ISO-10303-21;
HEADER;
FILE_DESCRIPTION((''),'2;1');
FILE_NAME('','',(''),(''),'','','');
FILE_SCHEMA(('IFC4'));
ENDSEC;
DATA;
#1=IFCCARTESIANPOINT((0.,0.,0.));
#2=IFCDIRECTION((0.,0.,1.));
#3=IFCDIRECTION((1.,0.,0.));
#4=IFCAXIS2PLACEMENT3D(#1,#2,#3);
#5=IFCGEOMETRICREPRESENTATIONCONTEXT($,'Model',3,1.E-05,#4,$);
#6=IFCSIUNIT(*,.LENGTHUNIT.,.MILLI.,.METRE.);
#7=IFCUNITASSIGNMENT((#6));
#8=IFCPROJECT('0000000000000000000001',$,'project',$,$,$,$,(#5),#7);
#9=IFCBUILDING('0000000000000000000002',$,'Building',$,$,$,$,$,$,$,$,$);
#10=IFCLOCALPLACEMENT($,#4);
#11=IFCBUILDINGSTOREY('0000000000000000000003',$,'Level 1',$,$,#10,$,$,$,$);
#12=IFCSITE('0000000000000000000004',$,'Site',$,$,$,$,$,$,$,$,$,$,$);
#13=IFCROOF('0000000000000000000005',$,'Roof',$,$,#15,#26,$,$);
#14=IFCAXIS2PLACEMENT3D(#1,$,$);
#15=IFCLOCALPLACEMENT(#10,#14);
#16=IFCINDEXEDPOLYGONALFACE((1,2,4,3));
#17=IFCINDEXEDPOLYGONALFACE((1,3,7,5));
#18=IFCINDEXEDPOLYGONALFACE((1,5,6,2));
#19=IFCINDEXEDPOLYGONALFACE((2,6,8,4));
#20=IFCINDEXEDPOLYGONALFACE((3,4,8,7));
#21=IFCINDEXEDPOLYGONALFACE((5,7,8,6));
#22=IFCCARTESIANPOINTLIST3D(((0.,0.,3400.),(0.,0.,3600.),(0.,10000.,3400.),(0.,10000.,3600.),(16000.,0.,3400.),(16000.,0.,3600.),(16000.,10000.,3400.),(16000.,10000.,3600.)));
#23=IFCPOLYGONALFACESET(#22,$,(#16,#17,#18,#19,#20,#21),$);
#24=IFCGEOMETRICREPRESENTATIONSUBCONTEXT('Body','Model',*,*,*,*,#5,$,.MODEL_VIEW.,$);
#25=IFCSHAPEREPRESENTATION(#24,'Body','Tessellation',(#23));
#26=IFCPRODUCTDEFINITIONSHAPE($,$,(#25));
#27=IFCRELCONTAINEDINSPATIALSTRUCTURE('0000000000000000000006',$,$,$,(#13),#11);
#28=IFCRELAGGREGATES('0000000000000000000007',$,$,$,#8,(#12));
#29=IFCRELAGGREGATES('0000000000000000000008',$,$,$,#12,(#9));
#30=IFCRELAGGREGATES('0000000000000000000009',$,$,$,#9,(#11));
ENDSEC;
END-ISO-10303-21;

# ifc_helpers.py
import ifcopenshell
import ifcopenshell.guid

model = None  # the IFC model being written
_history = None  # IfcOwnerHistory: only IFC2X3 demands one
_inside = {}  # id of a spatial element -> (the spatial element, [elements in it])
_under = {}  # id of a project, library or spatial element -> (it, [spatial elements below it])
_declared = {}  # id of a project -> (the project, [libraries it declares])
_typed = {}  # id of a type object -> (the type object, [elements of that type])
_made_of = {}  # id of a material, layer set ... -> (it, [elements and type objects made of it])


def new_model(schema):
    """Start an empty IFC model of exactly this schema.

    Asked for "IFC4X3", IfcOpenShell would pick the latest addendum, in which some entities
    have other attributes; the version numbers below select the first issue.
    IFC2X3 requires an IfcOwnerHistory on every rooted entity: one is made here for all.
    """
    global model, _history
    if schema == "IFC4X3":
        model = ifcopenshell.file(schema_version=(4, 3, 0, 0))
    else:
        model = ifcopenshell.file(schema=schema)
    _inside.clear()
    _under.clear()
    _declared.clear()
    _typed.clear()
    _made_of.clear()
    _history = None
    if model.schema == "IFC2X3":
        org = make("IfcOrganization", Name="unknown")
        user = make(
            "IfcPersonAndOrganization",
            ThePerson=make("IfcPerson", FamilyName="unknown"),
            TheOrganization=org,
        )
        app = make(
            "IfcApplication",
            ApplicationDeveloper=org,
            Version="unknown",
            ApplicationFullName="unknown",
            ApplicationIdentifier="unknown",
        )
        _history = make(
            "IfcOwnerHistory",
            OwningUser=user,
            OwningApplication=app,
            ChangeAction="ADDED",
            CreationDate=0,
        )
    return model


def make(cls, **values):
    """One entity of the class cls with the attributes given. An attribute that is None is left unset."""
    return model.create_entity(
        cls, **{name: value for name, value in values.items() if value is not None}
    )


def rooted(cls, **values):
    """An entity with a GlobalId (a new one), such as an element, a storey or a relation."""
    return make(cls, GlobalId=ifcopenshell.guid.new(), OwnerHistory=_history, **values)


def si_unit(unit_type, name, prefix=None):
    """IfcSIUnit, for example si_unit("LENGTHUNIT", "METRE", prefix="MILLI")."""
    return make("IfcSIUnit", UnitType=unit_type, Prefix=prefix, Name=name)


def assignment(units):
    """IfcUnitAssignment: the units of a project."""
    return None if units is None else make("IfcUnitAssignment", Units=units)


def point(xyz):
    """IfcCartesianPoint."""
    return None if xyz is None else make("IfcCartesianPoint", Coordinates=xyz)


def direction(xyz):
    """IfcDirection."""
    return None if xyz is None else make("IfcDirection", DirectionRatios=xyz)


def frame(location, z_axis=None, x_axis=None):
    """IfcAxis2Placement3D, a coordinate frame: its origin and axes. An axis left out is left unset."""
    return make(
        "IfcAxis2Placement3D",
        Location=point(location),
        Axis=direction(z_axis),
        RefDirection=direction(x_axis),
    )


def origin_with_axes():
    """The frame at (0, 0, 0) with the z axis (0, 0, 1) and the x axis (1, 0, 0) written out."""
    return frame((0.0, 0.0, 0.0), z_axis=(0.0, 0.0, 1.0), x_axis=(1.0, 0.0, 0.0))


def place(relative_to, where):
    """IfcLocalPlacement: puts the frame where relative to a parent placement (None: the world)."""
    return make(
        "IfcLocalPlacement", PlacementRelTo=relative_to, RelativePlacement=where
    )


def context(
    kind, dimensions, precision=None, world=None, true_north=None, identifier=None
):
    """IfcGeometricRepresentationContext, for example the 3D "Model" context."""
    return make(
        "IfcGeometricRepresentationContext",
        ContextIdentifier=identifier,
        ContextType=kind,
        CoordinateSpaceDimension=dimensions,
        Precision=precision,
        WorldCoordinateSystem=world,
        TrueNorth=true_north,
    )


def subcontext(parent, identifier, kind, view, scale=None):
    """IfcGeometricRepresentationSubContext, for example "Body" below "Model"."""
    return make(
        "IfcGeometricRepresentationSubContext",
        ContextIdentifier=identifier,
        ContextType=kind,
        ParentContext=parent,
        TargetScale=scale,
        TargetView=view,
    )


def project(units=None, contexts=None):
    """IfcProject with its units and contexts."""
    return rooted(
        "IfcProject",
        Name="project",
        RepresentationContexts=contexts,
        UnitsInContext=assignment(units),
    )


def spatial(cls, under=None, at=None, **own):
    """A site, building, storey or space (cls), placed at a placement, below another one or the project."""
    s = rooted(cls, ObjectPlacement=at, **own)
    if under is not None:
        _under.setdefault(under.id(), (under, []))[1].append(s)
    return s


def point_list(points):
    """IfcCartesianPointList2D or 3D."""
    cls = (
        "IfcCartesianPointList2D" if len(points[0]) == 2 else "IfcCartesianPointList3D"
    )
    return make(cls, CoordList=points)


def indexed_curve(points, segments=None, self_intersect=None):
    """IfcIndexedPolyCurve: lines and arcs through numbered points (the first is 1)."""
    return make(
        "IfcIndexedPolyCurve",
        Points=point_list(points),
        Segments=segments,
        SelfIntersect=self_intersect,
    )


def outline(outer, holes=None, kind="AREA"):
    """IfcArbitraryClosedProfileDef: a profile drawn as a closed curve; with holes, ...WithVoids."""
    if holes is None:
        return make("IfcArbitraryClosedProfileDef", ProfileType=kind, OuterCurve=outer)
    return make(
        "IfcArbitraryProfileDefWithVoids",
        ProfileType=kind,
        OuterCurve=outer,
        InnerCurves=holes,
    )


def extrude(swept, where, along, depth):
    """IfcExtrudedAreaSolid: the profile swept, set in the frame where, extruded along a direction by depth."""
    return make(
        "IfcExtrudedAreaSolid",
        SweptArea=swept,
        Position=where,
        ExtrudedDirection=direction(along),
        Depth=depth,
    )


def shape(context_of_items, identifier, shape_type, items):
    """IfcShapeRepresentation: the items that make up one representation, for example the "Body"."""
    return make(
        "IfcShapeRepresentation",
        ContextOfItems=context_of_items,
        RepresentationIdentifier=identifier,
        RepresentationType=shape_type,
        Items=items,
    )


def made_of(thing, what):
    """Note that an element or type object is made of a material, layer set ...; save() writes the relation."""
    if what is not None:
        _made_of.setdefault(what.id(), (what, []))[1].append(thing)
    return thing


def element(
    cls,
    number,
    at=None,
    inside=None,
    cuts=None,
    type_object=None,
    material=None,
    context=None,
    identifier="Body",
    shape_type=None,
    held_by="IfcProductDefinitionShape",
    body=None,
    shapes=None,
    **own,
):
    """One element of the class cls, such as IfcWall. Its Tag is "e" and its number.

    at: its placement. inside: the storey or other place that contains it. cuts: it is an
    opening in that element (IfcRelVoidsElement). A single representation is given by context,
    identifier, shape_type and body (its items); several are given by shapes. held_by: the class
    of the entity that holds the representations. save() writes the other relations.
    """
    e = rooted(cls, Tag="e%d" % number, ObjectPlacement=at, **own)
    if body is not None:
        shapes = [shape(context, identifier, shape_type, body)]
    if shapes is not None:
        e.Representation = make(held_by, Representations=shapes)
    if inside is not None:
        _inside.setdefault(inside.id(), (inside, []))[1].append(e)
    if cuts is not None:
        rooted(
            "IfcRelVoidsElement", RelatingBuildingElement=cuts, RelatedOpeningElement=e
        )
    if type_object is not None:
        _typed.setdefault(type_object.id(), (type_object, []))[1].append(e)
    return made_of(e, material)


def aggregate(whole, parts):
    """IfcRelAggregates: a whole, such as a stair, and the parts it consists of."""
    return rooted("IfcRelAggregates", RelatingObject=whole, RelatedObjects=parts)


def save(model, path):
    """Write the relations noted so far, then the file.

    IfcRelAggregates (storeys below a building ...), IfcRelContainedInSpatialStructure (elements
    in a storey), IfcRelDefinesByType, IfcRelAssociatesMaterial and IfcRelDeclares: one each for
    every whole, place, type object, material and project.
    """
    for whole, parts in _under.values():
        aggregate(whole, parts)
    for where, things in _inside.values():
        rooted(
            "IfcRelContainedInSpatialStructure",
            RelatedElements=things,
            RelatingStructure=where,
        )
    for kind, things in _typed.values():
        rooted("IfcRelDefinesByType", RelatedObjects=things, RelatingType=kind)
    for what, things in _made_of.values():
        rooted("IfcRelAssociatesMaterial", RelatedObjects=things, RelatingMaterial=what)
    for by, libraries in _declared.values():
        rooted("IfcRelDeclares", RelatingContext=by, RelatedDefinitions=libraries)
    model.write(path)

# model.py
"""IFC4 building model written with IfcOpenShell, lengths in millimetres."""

from ifc_helpers import new_model, si_unit, frame, origin_with_axes, place, context, subcontext, project, spatial, indexed_curve, outline, extrude, element, save


model = new_model("IFC4")

# Units and contexts
model_context = context("Model", 3, precision=1e-05, world=origin_with_axes())
body_context = subcontext(model_context, "Body", "Model", "MODEL_VIEW")
ifc_project = project(units=[si_unit("LENGTHUNIT", "METRE", prefix="MILLI")], contexts=[model_context])

# Site, building, storey
site = spatial("IfcSite", under=ifc_project, Name="Site")
building = spatial("IfcBuilding", under=site, Name="Building")
storey_placement = place(None, origin_with_axes())
storey = spatial("IfcBuildingStorey", under=building, at=storey_placement, Name="Level 1")

# Roof
roof_placement = place(storey_placement, frame((0.0, 0.0, 3400.0), z_axis=(0.0, 0.0, 1.0), x_axis=(1.0, 0.0, 0.0)))
element("IfcRoof", 1, at=roof_placement, inside=storey, Name="Roof", context=body_context, shape_type="SweptSolid", body=[
    extrude(outline(indexed_curve([(0.0, 0.0), (16000.0, 0.0), (16000.0, 10000.0), (0.0, 10000.0), (0.0, 0.0)])), None, (0.0, 0.0, 1.0), 200.0),
])

save(model, "model.ifc")
